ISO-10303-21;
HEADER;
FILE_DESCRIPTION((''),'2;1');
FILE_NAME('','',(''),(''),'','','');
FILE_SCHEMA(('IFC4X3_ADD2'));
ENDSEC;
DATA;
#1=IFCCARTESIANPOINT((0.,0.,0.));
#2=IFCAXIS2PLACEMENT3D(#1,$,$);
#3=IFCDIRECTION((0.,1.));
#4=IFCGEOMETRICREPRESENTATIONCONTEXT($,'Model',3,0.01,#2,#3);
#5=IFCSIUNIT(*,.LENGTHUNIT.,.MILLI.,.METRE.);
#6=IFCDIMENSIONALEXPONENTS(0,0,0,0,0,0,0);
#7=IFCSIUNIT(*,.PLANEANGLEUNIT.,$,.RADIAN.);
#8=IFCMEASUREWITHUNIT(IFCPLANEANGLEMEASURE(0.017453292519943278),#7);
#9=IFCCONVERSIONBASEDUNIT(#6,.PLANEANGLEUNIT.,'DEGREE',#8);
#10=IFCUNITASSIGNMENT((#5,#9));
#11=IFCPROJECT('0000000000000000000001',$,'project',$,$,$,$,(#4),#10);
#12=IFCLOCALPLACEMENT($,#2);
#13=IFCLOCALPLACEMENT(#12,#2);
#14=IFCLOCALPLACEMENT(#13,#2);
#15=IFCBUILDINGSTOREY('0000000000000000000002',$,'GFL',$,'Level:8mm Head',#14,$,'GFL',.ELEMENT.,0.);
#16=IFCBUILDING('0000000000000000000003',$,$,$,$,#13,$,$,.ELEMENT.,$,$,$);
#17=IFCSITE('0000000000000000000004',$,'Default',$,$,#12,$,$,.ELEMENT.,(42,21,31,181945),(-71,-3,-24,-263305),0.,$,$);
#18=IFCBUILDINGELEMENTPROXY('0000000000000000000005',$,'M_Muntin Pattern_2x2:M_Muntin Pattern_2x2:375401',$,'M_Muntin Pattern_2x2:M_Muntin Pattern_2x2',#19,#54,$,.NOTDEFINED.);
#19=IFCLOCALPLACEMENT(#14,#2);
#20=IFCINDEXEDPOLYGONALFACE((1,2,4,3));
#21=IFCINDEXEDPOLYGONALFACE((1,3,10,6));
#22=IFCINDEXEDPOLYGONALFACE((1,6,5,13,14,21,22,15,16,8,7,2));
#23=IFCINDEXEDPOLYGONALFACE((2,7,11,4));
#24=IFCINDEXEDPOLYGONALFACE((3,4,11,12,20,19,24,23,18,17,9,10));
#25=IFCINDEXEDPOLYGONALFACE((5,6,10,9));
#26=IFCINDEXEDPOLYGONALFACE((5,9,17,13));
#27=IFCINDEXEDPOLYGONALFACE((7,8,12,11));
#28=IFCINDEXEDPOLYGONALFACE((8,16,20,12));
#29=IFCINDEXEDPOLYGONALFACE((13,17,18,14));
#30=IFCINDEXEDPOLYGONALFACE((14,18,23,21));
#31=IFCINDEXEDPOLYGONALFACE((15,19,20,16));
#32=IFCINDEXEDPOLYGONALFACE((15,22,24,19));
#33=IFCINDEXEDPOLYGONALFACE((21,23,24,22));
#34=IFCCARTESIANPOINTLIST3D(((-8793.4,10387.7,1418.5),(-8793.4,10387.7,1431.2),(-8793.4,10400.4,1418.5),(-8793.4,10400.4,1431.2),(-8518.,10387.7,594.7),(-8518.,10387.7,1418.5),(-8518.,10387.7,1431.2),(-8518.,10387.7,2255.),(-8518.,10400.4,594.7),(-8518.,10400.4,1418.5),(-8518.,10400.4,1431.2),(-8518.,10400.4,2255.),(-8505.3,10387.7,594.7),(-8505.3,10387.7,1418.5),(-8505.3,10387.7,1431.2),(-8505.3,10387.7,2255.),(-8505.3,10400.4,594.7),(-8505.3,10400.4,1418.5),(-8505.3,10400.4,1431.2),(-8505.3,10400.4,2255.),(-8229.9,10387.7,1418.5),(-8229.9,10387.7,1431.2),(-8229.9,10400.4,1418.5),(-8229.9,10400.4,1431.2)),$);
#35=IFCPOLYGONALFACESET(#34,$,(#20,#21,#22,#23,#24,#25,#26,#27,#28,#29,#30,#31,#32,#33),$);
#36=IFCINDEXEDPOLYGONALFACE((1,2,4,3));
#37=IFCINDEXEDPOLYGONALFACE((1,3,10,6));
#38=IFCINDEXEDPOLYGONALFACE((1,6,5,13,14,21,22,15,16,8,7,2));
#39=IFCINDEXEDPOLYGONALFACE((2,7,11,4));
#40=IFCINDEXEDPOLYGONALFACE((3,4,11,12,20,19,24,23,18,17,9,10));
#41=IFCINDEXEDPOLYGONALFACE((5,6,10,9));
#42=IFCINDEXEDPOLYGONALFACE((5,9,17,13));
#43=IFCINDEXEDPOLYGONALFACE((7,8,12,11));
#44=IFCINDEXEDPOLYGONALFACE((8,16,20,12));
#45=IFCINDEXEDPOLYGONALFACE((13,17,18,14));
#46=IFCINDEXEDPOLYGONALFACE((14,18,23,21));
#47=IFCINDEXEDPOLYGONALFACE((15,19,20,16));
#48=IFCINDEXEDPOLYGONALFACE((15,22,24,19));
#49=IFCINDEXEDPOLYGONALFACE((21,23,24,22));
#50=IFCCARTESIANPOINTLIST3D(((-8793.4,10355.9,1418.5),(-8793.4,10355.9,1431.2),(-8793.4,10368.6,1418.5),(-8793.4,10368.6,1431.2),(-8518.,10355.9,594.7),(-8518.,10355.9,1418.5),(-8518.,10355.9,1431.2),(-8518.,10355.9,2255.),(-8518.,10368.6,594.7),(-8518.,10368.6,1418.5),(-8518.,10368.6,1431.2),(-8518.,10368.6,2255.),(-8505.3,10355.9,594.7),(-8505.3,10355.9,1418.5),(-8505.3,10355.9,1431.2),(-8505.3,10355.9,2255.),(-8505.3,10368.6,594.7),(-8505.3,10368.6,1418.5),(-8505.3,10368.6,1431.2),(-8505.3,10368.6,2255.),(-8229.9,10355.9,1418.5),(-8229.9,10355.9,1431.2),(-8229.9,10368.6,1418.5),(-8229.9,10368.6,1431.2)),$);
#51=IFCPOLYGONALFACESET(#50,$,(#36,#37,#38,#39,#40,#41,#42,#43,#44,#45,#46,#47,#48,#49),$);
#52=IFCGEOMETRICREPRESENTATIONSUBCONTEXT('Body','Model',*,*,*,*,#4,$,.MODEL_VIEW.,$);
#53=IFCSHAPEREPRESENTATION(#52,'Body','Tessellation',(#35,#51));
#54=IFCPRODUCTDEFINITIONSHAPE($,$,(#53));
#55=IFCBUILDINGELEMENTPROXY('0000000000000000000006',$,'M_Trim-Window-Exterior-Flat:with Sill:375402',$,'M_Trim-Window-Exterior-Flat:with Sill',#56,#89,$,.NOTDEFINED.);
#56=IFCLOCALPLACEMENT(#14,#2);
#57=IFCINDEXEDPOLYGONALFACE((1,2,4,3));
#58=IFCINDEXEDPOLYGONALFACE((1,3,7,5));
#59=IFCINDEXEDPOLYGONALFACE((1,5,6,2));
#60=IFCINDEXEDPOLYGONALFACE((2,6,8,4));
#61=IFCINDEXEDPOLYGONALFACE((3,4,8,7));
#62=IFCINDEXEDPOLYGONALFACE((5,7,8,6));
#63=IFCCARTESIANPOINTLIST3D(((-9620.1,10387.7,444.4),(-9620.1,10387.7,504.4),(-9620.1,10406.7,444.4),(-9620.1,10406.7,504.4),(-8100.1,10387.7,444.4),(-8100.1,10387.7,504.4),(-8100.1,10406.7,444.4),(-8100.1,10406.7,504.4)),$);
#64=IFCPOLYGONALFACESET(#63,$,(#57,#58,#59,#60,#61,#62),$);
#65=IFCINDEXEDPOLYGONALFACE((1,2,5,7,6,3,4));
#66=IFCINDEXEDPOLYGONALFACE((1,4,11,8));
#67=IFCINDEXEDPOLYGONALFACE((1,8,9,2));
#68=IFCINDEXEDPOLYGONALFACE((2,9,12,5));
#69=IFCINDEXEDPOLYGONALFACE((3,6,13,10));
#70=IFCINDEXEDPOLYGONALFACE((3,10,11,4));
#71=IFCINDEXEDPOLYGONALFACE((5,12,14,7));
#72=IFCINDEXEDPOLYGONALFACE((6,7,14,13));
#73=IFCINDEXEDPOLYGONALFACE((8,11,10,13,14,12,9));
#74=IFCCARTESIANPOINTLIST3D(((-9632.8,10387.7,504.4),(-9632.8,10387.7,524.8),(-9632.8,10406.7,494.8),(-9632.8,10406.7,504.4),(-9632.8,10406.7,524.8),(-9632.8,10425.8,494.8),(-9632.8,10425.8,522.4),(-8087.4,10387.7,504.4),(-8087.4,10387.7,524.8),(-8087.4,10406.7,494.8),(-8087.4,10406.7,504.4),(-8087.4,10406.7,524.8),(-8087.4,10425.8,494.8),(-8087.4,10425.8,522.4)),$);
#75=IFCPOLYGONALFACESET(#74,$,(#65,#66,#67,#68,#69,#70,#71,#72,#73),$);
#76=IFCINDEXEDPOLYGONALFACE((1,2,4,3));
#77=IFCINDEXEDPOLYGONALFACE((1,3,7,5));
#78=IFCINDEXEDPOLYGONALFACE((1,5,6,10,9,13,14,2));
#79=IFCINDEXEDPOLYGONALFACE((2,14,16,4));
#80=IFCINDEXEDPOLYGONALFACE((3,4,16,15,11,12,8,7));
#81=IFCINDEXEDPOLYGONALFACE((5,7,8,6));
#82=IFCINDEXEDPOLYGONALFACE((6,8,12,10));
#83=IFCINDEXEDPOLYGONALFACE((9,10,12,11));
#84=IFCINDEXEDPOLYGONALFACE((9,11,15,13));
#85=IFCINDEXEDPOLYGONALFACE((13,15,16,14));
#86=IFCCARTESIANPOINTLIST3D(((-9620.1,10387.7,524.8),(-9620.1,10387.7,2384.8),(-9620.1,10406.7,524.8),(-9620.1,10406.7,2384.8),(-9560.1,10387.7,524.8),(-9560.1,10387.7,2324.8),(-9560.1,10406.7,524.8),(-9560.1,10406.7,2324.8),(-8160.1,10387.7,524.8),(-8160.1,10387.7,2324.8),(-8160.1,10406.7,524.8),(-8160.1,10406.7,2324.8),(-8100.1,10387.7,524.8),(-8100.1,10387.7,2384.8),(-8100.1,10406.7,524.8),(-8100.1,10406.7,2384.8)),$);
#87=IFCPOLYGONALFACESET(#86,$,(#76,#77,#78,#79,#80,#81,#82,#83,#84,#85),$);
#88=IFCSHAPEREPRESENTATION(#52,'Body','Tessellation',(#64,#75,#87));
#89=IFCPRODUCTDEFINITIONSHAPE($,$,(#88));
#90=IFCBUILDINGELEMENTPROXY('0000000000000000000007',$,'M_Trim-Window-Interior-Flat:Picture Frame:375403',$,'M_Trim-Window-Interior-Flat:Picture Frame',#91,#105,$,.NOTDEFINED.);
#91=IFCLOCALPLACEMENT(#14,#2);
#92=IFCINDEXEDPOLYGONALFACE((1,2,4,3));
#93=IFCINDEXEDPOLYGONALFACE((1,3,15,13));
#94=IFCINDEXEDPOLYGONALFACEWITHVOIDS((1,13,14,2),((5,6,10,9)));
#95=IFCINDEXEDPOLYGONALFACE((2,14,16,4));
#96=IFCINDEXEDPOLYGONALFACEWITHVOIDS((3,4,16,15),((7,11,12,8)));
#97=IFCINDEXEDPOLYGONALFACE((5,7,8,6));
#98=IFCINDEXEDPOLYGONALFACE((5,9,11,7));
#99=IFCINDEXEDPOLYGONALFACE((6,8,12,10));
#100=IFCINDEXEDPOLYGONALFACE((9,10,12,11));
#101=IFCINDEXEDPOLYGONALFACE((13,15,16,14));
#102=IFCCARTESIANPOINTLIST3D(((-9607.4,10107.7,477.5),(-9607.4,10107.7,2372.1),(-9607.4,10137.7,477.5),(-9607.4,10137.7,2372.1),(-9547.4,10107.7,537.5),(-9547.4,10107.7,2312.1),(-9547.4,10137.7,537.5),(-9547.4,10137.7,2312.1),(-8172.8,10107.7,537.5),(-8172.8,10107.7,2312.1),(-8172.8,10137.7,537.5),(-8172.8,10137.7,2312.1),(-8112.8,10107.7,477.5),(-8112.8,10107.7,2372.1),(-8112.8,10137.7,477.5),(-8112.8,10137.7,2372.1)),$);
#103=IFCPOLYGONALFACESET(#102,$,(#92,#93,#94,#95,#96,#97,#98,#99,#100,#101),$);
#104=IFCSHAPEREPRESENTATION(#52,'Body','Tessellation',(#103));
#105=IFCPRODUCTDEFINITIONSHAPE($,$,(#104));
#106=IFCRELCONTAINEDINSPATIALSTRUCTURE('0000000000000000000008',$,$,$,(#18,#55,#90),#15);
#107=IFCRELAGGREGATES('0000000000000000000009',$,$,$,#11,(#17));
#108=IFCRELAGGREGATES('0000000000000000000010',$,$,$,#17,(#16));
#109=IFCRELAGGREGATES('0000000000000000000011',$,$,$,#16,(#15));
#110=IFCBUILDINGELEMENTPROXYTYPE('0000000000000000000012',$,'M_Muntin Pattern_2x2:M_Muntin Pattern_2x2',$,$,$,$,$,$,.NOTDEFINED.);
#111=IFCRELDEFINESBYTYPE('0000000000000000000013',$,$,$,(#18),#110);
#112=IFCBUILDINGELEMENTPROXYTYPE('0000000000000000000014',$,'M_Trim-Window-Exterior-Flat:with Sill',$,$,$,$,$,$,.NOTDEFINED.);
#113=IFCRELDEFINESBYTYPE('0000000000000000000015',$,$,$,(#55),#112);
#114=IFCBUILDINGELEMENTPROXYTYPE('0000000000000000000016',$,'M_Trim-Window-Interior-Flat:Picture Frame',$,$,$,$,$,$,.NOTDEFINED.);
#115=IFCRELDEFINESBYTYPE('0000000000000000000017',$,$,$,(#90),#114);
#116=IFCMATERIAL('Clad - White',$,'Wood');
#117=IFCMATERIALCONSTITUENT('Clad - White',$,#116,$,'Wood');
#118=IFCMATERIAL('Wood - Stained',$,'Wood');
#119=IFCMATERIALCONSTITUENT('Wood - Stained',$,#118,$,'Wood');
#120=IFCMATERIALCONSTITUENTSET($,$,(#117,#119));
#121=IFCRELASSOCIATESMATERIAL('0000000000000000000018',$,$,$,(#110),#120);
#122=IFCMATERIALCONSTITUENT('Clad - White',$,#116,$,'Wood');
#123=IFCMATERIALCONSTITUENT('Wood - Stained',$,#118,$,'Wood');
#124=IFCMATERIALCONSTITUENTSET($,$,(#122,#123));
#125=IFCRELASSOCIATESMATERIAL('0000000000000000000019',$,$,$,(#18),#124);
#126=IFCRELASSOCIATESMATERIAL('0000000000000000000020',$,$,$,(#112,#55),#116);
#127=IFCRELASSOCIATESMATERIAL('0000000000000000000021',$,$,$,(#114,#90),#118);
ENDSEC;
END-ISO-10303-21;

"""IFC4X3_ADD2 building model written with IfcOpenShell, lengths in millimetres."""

from ifc_helpers import new_model, entity, si_unit, converted_unit, direction, frame, frame_2d, origin, place, context, subcontext, project, spatial, polyline, rectangle, outline, extrude, source, transform, mapped, material, constituent, constituent_set, type_object, type_shapes, element, save


model = new_model("IFC4X3_ADD2")

# Units and contexts
model_context = context("Model", 3, precision=0.01, world=origin(), true_north=direction((0.0, 1.0)))
body_context = subcontext(model_context, "Body", "Model", "MODEL_VIEW")
ifc_project = project(units=[si_unit("LENGTHUNIT", "METRE", prefix="MILLI"), converted_unit("PLANEANGLEUNIT", "DEGREE", entity("IfcPlaneAngleMeasure", 0.017453292519943278), si_unit("PLANEANGLEUNIT", "RADIAN"), dimensions=[0, 0, 0, 0, 0, 0, 0])], contexts=[model_context])

# Site, building, storey
site_placement = place(None, origin())
site = spatial("IfcSite", under=ifc_project, at=site_placement, Name="Default", CompositionType="ELEMENT", RefLatitude=(42, 21, 31, 181945), RefLongitude=(-71, -3, -24, -263305), RefElevation=0.0)
building_placement = place(site_placement, origin())
building = spatial("IfcBuilding", under=site, at=building_placement, CompositionType="ELEMENT")
storey_placement = place(building_placement, origin())
storey = spatial("IfcBuildingStorey", under=building, at=storey_placement, Name="GFL", ObjectType="Level:8mm Head", LongName="GFL", CompositionType="ELEMENT", Elevation=0.0)

# Building element proxies
ifc_material_1 = material(Name="Clad - White", Category="Wood")
ifc_material_2 = material(Name="Wood - Stained", Category="Wood")
ifc_constituent_1 = constituent(ifc_material_1, Name="Clad - White", Category="Wood")
ifc_constituent_2 = constituent(ifc_material_2, Name="Wood - Stained", Category="Wood")
ifc_constituent_set_1 = constituent_set(constituents=[ifc_constituent_1, ifc_constituent_2])
ifc_constituent_3 = constituent(ifc_material_1, Name="Clad - White", Category="Wood")
ifc_constituent_4 = constituent(ifc_material_2, Name="Wood - Stained", Category="Wood")
ifc_constituent_set_2 = constituent_set(constituents=[ifc_constituent_3, ifc_constituent_4])
building_element_proxy_type_1 = type_object("IfcBuildingElementProxyType", Name="M_Muntin Pattern_2x2:M_Muntin Pattern_2x2", PredefinedType="NOTDEFINED", material=ifc_constituent_set_2)
shared_shape_1 = source(origin(), body_context, "Body", "SweptSolid", [
    extrude(outline(polyline([(6.4, -6.4), (830.1, -6.4), (830.1, 6.3), (6.4, 6.3), (6.4, 281.7), (-6.3, 281.7), (-6.3, 6.3), (-830.2, 6.3), (-830.2, -6.4), (-6.3, -6.4), (-6.3, -281.7), (6.4, -281.7), (6.4, -6.4)])), frame((0.0, -22.2, 830.1), z_axis=(0.0, 1.0, 0.0), x_axis=(0.0, 0.0, 1.0)), (0.0, 0.0, 1.0), 12.7),
    extrude(outline(polyline([(6.4, -6.4), (830.2, -6.4), (830.2, 6.3), (6.4, 6.3), (6.4, 281.7), (-6.3, 281.7), (-6.3, 6.3), (-830.2, 6.3), (-830.2, -6.4), (-6.3, -6.4), (-6.3, -281.7), (6.4, -281.7), (6.4, -6.4)])), frame((0.0, 9.5, 830.2), z_axis=(0.0, 1.0, 0.0), x_axis=(0.0, 0.0, 1.0)), (0.0, 0.0, 1.0), 12.7),
])
type_shapes(building_element_proxy_type_1, [shared_shape_1])
proxy_1_placement = place(storey_placement, frame((-8511.7, 10378.2, 594.7), z_axis=(0.0, 0.0, 1.0), x_axis=(-1.0, 0.0, 0.0)))
element("IfcBuildingElementProxy", 1, at=proxy_1_placement, inside=storey, type_object=building_element_proxy_type_1, material=ifc_constituent_set_1, Name="M_Muntin Pattern_2x2:M_Muntin Pattern_2x2:375401", ObjectType="M_Muntin Pattern_2x2:M_Muntin Pattern_2x2", PredefinedType="NOTDEFINED", context=body_context, shape_type="MappedRepresentation", body=[
    mapped(shared_shape_1, transform((0.0, 0.0, 0.0), scale=1.0)),
])
building_element_proxy_type_2 = type_object("IfcBuildingElementProxyType", Name="M_Trim-Window-Exterior-Flat:with Sill", PredefinedType="NOTDEFINED", material=ifc_material_1)
shared_shape_2 = source(origin(), body_context, "Body", "SweptSolid", [
    extrude(rectangle(XDim=1520.0, YDim=60.0, at=frame_2d((0.0, 0.0), x_axis=(1.0, 0.0))), frame((0.0, -1850.4, 0.0), z_axis=(0.0, 0.0, 1.0), x_axis=(-1.0, 0.0, 0.0)), (0.0, 0.0, 1.0), 19.0),
    extrude(outline(polyline([(-19.0, -15.2), (0.0, -15.2), (0.0, -5.7), (19.0, -5.7), (19.0, 14.8), (0.0, 14.8), (-19.0, 12.3), (-19.0, -15.2)])), frame((-772.7, -1814.8, 19.0), z_axis=(1.0, 0.0, 0.0), x_axis=(0.0, 0.0, -1.0)), (0.0, 0.0, 1.0), 1545.4),
    extrude(outline(polyline([(-945.0, -760.0), (915.0, -760.0), (915.0, -700.0), (-885.0, -700.0), (-885.0, 700.0), (915.0, 700.0), (915.0, 760.0), (-945.0, 760.0), (-945.0, -760.0)])), frame((0.0, -885.0, 0.0), z_axis=(0.0, 0.0, 1.0), x_axis=(0.0, -1.0, 0.0)), (0.0, 0.0, 1.0), 19.0),
])
type_shapes(building_element_proxy_type_2, [shared_shape_2])
proxy_2_placement = place(storey_placement, frame((-8860.1, 10387.7, 2324.8), z_axis=(0.0, 1.0, 0.0), x_axis=(-1.0, 0.0, 0.0)))
element("IfcBuildingElementProxy", 2, at=proxy_2_placement, inside=storey, type_object=building_element_proxy_type_2, material=ifc_material_1, Name="M_Trim-Window-Exterior-Flat:with Sill:375402", ObjectType="M_Trim-Window-Exterior-Flat:with Sill", PredefinedType="NOTDEFINED", context=body_context, shape_type="MappedRepresentation", body=[
    mapped(shared_shape_2, transform((0.0, 0.0, 0.0), scale=1.0)),
])
building_element_proxy_type_3 = type_object("IfcBuildingElementProxyType", Name="M_Trim-Window-Interior-Flat:Picture Frame", PredefinedType="NOTDEFINED", material=ifc_material_2)
shared_shape_3 = source(origin(), body_context, "Body", "SweptSolid", [
    extrude(outline(polyline([(-747.3, -947.3), (747.3, -947.3), (747.3, 947.3), (-747.3, 947.3), (-747.3, -947.3)]), holes=[polyline([(-687.3, -887.3), (-687.3, 887.3), (687.3, 887.3), (687.3, -887.3), (-687.3, -887.3)])]), frame((0.0, -900.0, 0.0), z_axis=(0.0, 0.0, 1.0), x_axis=(-1.0, 0.0, 0.0)), (0.0, 0.0, 1.0), 30.0),
])
type_shapes(building_element_proxy_type_3, [shared_shape_3])
proxy_3_placement = place(storey_placement, frame((-8860.1, 10137.7, 2324.8), z_axis=(0.0, -1.0, 0.0), x_axis=(1.0, 0.0, 0.0)))
element("IfcBuildingElementProxy", 3, at=proxy_3_placement, inside=storey, type_object=building_element_proxy_type_3, material=ifc_material_2, Name="M_Trim-Window-Interior-Flat:Picture Frame:375403", ObjectType="M_Trim-Window-Interior-Flat:Picture Frame", PredefinedType="NOTDEFINED", context=body_context, shape_type="MappedRepresentation", body=[
    mapped(shared_shape_3, transform((0.0, 0.0, 0.0), scale=1.0)),
])

save(model, "model.ifc")
